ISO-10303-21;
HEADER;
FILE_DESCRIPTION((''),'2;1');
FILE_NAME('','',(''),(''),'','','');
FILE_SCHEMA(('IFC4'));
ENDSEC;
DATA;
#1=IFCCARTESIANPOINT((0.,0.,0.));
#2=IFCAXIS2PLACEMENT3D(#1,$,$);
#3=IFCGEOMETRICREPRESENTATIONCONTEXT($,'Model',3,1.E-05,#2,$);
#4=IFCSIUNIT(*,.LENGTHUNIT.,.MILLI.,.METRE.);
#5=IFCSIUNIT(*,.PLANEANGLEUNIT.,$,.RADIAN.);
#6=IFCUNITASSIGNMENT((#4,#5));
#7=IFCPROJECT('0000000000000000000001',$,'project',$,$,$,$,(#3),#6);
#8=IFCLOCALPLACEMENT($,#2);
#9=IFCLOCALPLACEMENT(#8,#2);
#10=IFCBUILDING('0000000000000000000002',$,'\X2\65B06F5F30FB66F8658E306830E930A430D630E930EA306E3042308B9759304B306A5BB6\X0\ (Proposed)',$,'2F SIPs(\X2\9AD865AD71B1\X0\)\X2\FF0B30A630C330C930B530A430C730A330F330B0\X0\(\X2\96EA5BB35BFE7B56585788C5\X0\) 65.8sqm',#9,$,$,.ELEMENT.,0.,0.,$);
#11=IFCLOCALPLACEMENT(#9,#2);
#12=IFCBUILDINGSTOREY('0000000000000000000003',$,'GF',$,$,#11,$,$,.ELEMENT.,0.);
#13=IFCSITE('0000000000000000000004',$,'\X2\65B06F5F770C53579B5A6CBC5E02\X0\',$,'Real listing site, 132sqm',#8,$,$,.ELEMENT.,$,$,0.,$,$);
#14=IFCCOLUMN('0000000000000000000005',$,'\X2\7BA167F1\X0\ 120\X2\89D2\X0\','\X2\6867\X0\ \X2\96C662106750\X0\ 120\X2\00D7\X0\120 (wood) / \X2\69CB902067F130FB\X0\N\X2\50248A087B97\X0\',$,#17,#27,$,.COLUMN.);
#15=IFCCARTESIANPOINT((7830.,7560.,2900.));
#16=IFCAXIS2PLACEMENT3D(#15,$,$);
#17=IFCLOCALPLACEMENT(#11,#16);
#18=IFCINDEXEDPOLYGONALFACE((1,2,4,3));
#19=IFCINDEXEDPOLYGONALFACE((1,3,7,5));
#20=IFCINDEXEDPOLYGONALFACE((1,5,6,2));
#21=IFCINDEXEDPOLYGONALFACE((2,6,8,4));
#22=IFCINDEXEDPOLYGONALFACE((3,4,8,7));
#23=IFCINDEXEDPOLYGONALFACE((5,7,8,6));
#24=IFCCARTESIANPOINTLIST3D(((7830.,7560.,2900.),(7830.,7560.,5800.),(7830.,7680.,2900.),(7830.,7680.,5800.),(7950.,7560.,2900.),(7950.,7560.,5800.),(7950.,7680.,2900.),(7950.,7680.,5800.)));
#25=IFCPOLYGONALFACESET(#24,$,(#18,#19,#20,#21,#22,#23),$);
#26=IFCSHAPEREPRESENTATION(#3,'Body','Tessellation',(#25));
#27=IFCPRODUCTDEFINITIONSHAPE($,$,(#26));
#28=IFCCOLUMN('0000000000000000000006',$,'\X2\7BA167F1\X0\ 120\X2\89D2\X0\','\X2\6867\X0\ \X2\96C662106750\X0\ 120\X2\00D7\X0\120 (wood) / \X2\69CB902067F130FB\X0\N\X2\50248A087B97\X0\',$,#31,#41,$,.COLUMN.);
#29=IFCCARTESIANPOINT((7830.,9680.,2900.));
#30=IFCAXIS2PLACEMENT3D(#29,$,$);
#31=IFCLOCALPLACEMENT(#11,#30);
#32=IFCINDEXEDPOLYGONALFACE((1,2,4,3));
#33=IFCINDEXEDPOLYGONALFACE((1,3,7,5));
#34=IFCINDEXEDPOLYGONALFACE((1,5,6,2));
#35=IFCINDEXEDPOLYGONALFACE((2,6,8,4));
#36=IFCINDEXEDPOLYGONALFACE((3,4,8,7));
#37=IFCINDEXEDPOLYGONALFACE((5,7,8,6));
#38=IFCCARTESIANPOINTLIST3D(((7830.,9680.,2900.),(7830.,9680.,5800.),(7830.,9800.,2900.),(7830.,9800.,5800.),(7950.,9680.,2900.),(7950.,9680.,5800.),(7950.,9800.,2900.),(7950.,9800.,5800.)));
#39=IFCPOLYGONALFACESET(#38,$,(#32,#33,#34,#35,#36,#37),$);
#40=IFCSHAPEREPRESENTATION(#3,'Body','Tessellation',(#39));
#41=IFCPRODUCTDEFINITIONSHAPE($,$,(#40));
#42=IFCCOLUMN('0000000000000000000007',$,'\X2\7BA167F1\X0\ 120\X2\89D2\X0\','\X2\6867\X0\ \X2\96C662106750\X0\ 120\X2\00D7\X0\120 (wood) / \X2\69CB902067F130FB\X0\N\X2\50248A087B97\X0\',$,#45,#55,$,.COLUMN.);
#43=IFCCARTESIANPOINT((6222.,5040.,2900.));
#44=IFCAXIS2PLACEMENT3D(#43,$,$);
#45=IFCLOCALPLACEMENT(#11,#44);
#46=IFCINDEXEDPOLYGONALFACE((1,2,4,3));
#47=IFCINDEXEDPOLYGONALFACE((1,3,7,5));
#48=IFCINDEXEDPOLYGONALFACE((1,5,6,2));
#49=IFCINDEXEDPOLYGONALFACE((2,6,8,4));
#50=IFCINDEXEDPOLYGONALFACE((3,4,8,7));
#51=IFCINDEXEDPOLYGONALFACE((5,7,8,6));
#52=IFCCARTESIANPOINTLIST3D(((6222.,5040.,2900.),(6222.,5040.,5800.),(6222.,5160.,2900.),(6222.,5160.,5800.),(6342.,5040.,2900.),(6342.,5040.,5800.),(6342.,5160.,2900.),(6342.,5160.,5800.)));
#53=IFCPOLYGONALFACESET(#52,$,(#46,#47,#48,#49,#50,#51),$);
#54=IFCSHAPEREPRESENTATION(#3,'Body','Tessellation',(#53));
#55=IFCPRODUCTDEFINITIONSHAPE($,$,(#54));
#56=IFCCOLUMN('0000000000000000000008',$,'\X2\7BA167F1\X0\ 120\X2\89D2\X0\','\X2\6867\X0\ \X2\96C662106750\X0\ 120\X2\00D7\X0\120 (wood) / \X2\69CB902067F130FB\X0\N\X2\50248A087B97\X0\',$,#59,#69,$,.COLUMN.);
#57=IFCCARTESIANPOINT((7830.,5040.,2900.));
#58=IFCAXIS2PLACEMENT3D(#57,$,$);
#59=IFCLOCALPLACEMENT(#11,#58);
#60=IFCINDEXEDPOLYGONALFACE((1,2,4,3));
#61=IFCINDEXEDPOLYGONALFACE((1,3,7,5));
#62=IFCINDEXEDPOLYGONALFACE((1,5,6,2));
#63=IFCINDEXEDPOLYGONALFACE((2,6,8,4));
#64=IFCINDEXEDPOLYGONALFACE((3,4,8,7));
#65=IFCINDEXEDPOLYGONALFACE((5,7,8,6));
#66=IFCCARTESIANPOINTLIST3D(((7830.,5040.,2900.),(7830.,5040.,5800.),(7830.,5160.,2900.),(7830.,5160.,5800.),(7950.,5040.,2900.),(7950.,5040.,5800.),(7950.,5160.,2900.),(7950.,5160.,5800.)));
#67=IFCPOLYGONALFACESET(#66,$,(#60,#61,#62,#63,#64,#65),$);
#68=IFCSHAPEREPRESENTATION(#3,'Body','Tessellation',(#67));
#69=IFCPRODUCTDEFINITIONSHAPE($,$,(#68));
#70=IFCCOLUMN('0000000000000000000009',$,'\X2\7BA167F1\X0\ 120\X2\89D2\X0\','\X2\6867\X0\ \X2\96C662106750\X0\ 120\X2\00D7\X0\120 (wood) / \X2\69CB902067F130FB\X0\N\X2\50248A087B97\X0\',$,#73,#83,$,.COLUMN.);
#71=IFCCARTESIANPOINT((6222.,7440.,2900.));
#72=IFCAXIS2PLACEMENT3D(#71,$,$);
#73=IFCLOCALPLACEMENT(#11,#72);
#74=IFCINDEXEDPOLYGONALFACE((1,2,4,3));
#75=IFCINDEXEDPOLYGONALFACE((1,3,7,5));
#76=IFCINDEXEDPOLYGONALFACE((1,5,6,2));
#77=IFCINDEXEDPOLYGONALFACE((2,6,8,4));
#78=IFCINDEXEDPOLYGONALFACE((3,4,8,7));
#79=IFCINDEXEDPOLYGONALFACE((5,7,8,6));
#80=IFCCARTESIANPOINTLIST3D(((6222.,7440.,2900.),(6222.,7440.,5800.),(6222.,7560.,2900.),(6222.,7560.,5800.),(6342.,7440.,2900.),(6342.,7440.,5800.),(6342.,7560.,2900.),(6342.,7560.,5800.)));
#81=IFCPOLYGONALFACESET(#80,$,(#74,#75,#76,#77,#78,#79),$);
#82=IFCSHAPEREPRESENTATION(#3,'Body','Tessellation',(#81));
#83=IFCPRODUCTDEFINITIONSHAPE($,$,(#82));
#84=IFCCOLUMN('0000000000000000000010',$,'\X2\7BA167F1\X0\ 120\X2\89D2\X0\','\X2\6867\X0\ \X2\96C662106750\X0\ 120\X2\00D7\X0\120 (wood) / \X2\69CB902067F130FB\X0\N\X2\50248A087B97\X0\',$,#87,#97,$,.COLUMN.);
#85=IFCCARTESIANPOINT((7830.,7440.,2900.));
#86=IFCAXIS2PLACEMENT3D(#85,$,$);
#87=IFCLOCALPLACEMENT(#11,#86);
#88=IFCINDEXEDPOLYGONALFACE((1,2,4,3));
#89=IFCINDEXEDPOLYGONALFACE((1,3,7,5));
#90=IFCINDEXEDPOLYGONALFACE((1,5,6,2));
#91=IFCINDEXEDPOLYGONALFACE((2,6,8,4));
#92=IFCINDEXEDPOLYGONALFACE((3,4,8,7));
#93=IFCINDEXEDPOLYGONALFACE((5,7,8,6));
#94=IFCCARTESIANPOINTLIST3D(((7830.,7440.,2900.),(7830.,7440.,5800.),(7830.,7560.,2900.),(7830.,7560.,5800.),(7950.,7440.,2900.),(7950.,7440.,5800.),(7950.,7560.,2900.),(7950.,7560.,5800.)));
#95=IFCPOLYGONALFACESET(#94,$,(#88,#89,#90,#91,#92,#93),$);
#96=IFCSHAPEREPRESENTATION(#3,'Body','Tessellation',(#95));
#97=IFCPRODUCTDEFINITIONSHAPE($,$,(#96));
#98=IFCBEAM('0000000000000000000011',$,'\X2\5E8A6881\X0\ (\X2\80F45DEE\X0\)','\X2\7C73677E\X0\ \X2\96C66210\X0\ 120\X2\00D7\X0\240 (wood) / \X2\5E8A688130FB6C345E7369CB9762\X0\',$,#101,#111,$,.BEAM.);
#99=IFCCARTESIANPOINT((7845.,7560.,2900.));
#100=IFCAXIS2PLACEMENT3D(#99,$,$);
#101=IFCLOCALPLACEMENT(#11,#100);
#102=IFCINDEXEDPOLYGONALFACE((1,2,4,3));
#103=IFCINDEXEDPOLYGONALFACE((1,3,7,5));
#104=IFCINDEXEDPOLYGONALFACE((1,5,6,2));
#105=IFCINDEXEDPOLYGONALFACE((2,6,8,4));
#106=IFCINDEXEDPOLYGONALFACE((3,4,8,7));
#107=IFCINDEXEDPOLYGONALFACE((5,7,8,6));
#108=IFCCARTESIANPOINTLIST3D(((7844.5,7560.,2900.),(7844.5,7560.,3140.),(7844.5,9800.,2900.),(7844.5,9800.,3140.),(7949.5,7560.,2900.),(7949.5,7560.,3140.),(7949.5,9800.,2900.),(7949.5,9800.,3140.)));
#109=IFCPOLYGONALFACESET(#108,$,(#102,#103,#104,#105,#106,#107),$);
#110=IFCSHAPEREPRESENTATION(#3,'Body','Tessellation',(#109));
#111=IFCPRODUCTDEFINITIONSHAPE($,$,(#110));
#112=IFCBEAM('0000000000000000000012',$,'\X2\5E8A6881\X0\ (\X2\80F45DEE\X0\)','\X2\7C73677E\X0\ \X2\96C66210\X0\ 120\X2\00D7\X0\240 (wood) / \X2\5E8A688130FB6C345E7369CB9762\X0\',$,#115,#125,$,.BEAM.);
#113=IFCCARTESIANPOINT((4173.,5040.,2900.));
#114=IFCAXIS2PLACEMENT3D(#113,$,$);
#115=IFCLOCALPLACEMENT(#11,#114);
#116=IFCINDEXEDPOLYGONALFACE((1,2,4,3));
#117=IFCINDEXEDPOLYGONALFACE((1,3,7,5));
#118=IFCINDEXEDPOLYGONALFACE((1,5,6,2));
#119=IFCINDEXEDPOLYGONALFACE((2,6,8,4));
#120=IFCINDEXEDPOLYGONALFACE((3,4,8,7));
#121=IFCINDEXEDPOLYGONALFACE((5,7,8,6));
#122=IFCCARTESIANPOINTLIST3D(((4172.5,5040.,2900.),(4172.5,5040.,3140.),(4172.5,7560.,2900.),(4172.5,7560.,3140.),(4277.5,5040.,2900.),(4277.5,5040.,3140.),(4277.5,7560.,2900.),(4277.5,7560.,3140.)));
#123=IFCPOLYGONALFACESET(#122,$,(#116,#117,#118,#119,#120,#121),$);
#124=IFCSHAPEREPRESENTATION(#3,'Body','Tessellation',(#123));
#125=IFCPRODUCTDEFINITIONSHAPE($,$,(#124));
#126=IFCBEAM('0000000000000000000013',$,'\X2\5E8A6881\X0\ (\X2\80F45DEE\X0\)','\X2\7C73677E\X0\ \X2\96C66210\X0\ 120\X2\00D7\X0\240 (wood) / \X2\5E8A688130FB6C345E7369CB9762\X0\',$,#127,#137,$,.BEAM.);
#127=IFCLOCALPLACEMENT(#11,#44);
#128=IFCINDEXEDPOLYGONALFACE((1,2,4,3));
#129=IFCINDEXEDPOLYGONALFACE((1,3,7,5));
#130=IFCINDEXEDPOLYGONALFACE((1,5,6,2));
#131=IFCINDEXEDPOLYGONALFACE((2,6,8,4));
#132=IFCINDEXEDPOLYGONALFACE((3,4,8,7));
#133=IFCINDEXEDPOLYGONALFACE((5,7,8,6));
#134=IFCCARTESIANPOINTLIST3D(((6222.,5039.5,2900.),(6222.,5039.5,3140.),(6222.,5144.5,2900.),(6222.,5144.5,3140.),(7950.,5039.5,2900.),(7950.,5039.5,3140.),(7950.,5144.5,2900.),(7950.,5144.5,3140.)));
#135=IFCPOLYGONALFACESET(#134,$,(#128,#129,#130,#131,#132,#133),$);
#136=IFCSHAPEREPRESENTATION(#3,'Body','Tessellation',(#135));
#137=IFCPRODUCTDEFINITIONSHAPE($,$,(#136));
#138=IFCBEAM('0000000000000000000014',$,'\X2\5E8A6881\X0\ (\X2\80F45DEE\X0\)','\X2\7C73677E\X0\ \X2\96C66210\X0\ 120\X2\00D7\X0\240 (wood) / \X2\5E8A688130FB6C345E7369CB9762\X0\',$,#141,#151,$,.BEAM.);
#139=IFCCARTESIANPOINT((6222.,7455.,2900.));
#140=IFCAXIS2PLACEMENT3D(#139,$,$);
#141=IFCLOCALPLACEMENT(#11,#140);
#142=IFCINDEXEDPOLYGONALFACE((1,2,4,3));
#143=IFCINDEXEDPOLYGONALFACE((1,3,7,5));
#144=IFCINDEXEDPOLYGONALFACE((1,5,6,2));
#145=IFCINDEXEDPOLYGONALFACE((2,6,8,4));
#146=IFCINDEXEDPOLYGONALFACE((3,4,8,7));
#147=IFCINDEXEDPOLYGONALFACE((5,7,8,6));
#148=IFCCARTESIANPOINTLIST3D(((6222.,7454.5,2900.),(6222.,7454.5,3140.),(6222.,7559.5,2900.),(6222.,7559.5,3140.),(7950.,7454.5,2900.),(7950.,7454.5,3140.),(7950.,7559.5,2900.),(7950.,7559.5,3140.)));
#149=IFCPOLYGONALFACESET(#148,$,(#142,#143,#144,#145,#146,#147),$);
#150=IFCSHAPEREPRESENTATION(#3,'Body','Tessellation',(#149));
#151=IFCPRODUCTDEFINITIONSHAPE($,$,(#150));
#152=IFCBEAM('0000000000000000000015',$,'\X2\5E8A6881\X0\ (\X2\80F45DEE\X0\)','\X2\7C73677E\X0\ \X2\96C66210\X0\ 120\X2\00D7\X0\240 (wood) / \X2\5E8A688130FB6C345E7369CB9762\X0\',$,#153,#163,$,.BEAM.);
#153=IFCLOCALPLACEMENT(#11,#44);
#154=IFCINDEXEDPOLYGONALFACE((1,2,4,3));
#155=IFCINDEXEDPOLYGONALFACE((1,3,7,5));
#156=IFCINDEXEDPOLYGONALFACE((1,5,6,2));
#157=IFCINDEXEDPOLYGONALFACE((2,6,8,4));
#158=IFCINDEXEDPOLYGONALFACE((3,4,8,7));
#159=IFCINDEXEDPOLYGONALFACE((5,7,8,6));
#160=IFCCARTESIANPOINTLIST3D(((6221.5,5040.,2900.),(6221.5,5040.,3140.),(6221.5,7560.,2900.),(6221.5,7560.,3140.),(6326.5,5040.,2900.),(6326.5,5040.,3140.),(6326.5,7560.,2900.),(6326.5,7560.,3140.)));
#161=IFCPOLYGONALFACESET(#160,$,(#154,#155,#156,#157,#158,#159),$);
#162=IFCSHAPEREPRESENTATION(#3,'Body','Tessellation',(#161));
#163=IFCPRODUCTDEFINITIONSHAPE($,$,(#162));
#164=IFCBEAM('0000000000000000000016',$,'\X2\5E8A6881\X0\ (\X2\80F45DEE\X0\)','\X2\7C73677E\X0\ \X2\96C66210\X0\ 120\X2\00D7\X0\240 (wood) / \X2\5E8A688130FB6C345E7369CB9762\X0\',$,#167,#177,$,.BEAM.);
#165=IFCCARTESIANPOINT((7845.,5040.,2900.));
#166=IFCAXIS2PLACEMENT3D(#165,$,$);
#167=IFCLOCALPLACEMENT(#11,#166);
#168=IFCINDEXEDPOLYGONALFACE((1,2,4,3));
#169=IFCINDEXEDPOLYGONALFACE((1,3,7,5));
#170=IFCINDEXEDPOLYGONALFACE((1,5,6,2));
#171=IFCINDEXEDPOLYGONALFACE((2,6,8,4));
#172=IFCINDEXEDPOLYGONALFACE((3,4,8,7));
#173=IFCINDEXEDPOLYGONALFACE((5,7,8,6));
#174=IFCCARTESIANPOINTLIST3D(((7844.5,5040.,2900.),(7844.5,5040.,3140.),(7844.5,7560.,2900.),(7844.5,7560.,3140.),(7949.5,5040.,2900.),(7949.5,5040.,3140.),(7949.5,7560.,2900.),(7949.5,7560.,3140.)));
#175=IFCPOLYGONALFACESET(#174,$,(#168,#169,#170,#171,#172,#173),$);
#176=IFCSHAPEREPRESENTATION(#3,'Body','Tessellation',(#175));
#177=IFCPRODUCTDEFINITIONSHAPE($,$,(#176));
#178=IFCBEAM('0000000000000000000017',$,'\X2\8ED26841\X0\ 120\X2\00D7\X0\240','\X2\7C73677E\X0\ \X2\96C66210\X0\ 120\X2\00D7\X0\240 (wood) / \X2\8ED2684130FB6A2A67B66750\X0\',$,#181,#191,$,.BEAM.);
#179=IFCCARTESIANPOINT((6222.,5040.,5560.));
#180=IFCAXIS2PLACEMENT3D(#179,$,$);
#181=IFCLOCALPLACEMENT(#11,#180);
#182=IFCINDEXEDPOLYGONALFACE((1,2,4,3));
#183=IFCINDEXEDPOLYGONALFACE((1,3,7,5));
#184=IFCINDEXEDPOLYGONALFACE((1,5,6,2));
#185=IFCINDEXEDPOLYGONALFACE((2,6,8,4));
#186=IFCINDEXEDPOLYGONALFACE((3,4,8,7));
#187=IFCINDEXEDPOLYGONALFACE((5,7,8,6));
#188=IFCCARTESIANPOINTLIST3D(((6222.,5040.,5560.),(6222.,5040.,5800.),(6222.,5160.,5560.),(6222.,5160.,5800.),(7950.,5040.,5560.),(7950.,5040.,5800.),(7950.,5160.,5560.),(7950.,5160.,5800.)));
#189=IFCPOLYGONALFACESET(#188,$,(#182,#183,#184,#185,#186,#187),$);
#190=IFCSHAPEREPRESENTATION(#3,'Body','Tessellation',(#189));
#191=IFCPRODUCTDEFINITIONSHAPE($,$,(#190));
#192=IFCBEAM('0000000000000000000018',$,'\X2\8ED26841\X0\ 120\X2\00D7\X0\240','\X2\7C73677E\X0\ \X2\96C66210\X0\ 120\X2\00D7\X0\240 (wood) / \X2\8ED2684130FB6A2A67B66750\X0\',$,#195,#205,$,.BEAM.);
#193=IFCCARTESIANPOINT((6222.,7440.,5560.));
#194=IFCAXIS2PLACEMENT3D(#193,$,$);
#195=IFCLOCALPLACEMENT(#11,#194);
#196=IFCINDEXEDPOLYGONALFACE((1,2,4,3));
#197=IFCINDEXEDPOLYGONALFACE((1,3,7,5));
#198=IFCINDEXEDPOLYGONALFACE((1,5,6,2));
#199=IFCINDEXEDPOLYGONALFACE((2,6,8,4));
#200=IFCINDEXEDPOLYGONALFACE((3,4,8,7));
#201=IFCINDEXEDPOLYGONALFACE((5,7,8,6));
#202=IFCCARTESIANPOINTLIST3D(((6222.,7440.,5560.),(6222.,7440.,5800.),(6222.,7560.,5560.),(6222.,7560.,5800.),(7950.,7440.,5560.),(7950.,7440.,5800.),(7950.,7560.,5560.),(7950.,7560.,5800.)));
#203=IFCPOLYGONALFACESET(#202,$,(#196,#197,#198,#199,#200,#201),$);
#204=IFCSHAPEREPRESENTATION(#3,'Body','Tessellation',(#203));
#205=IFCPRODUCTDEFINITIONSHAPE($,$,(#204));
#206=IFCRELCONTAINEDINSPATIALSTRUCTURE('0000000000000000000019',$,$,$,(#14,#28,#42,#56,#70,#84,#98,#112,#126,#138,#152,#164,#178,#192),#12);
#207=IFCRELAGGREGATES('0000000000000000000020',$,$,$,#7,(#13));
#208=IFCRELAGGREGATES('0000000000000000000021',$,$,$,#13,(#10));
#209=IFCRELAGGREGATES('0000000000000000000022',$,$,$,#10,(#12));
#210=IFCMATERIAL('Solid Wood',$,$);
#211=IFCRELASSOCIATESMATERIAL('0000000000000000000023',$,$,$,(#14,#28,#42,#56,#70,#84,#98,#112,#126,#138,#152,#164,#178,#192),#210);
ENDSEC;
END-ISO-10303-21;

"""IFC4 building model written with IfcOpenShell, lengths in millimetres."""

from ifc_helpers import new_model, si_unit, frame, frame_2d, origin, place, context, project, spatial, rectangle, extrude, material, element, save


model = new_model("IFC4")

# Units and contexts
model_context = context("Model", 3, precision=1e-05, world=origin())
ifc_project = project(units=[si_unit("LENGTHUNIT", "METRE", prefix="MILLI"), si_unit("PLANEANGLEUNIT", "RADIAN")], contexts=[model_context])

# Site, building, storey
site_placement = place(None, origin())
site = spatial("IfcSite", under=ifc_project, at=site_placement, Name="新潟県南魚沼市", ObjectType="Real listing site, 132sqm", CompositionType="ELEMENT", RefElevation=0.0)
building_placement = place(site_placement, origin())
building = spatial("IfcBuilding", under=site, at=building_placement, Name="新潟・書斎とライブラリのある静かな家 (Proposed)", ObjectType="2F SIPs(高断熱)＋ウッドサイディング(雪害対策塗装) 65.8sqm", CompositionType="ELEMENT", ElevationOfRefHeight=0.0, ElevationOfTerrain=0.0)
storey_placement = place(building_placement, origin())
storey = spatial("IfcBuildingStorey", under=building, at=storey_placement, Name="GF", CompositionType="ELEMENT", Elevation=0.0)

# Columns
ifc_material_1 = material(Name="Solid Wood")
column_1_placement = place(storey_placement, frame((7830.0, 7560.0, 2900.0)))
element("IfcColumn", 1, at=column_1_placement, inside=storey, material=ifc_material_1, Name="管柱 120角", Description="桧 集成材 120×120 (wood) / 構造柱・N値計算", PredefinedType="COLUMN", context=model_context, shape_type="SweptSolid", body=[
    extrude(rectangle(XDim=120.0, YDim=120.0, at=frame_2d((60.0, 60.0))), frame((7830.0, 7560.0, 2900.0)), (0.0, 0.0, 1.0), 2900.0),
])
column_2_placement = place(storey_placement, frame((7830.0, 9680.0, 2900.0)))
element("IfcColumn", 2, at=column_2_placement, inside=storey, material=ifc_material_1, Name="管柱 120角", Description="桧 集成材 120×120 (wood) / 構造柱・N値計算", PredefinedType="COLUMN", context=model_context, shape_type="SweptSolid", body=[
    extrude(rectangle(XDim=120.0, YDim=120.0, at=frame_2d((60.0, 60.0))), frame((7830.0, 9680.0, 2900.0)), (0.0, 0.0, 1.0), 2900.0),
])
column_3_placement = place(storey_placement, frame((6222.0, 5040.0, 2900.0)))
element("IfcColumn", 3, at=column_3_placement, inside=storey, material=ifc_material_1, Name="管柱 120角", Description="桧 集成材 120×120 (wood) / 構造柱・N値計算", PredefinedType="COLUMN", context=model_context, shape_type="SweptSolid", body=[
    extrude(rectangle(XDim=120.0, YDim=120.0, at=frame_2d((60.0, 60.0))), frame((6222.0, 5040.0, 2900.0)), (0.0, 0.0, 1.0), 2900.0),
])
column_4_placement = place(storey_placement, frame((7830.0, 5040.0, 2900.0)))
element("IfcColumn", 4, at=column_4_placement, inside=storey, material=ifc_material_1, Name="管柱 120角", Description="桧 集成材 120×120 (wood) / 構造柱・N値計算", PredefinedType="COLUMN", context=model_context, shape_type="SweptSolid", body=[
    extrude(rectangle(XDim=120.0, YDim=120.0, at=frame_2d((60.0, 60.0))), frame((7830.0, 5040.0, 2900.0)), (0.0, 0.0, 1.0), 2900.0),
])
column_5_placement = place(storey_placement, frame((6222.0, 7440.0, 2900.0)))
element("IfcColumn", 5, at=column_5_placement, inside=storey, material=ifc_material_1, Name="管柱 120角", Description="桧 集成材 120×120 (wood) / 構造柱・N値計算", PredefinedType="COLUMN", context=model_context, shape_type="SweptSolid", body=[
    extrude(rectangle(XDim=120.0, YDim=120.0, at=frame_2d((60.0, 60.0))), frame((6222.0, 7440.0, 2900.0)), (0.0, 0.0, 1.0), 2900.0),
])
column_6_placement = place(storey_placement, frame((7830.0, 7440.0, 2900.0)))
element("IfcColumn", 6, at=column_6_placement, inside=storey, material=ifc_material_1, Name="管柱 120角", Description="桧 集成材 120×120 (wood) / 構造柱・N値計算", PredefinedType="COLUMN", context=model_context, shape_type="SweptSolid", body=[
    extrude(rectangle(XDim=120.0, YDim=120.0, at=frame_2d((60.0, 60.0))), frame((7830.0, 7440.0, 2900.0)), (0.0, 0.0, 1.0), 2900.0),
])

# Beams
beam_1_placement = place(storey_placement, frame((7845.0, 7560.0, 2900.0)))
element("IfcBeam", 7, at=beam_1_placement, inside=storey, material=ifc_material_1, Name="床梁 (胴差)", Description="米松 集成 120×240 (wood) / 床梁・水平構面", PredefinedType="BEAM", context=model_context, shape_type="SweptSolid", body=[
    extrude(rectangle(XDim=105.0, YDim=2240.0, at=frame_2d((52.0, 1120.0))), frame((7845.0, 7560.0, 2900.0)), (0.0, 0.0, 1.0), 240.0),
])
beam_2_placement = place(storey_placement, frame((4173.0, 5040.0, 2900.0)))
element("IfcBeam", 8, at=beam_2_placement, inside=storey, material=ifc_material_1, Name="床梁 (胴差)", Description="米松 集成 120×240 (wood) / 床梁・水平構面", PredefinedType="BEAM", context=model_context, shape_type="SweptSolid", body=[
    extrude(rectangle(XDim=105.0, YDim=2520.0, at=frame_2d((52.0, 1260.0))), frame((4173.0, 5040.0, 2900.0)), (0.0, 0.0, 1.0), 240.0),
])
beam_3_placement = place(storey_placement, frame((6222.0, 5040.0, 2900.0)))
element("IfcBeam", 9, at=beam_3_placement, inside=storey, material=ifc_material_1, Name="床梁 (胴差)", Description="米松 集成 120×240 (wood) / 床梁・水平構面", PredefinedType="BEAM", context=model_context, shape_type="SweptSolid", body=[
    extrude(rectangle(XDim=1728.0, YDim=105.0, at=frame_2d((864.0, 52.0))), frame((6222.0, 5040.0, 2900.0)), (0.0, 0.0, 1.0), 240.0),
])
beam_4_placement = place(storey_placement, frame((6222.0, 7455.0, 2900.0)))
element("IfcBeam", 10, at=beam_4_placement, inside=storey, material=ifc_material_1, Name="床梁 (胴差)", Description="米松 集成 120×240 (wood) / 床梁・水平構面", PredefinedType="BEAM", context=model_context, shape_type="SweptSolid", body=[
    extrude(rectangle(XDim=1728.0, YDim=105.0, at=frame_2d((864.0, 52.0))), frame((6222.0, 7455.0, 2900.0)), (0.0, 0.0, 1.0), 240.0),
])
beam_5_placement = place(storey_placement, frame((6222.0, 5040.0, 2900.0)))
element("IfcBeam", 11, at=beam_5_placement, inside=storey, material=ifc_material_1, Name="床梁 (胴差)", Description="米松 集成 120×240 (wood) / 床梁・水平構面", PredefinedType="BEAM", context=model_context, shape_type="SweptSolid", body=[
    extrude(rectangle(XDim=105.0, YDim=2520.0, at=frame_2d((52.0, 1260.0))), frame((6222.0, 5040.0, 2900.0)), (0.0, 0.0, 1.0), 240.0),
])
beam_6_placement = place(storey_placement, frame((7845.0, 5040.0, 2900.0)))
element("IfcBeam", 12, at=beam_6_placement, inside=storey, material=ifc_material_1, Name="床梁 (胴差)", Description="米松 集成 120×240 (wood) / 床梁・水平構面", PredefinedType="BEAM", context=model_context, shape_type="SweptSolid", body=[
    extrude(rectangle(XDim=105.0, YDim=2520.0, at=frame_2d((52.0, 1260.0))), frame((7845.0, 5040.0, 2900.0)), (0.0, 0.0, 1.0), 240.0),
])
beam_7_placement = place(storey_placement, frame((6222.0, 5040.0, 5560.0)))
element("IfcBeam", 13, at=beam_7_placement, inside=storey, material=ifc_material_1, Name="軒桁 120×240", Description="米松 集成 120×240 (wood) / 軒桁・横架材", PredefinedType="BEAM", context=model_context, shape_type="SweptSolid", body=[
    extrude(rectangle(XDim=1728.0, YDim=120.0, at=frame_2d((864.0, 60.0))), frame((6222.0, 5040.0, 5560.0)), (0.0, 0.0, 1.0), 240.0),
])
beam_8_placement = place(storey_placement, frame((6222.0, 7440.0, 5560.0)))
element("IfcBeam", 14, at=beam_8_placement, inside=storey, material=ifc_material_1, Name="軒桁 120×240", Description="米松 集成 120×240 (wood) / 軒桁・横架材", PredefinedType="BEAM", context=model_context, shape_type="SweptSolid", body=[
    extrude(rectangle(XDim=1728.0, YDim=120.0, at=frame_2d((864.0, 60.0))), frame((6222.0, 7440.0, 5560.0)), (0.0, 0.0, 1.0), 240.0),
])

save(model, "model.ifc")
